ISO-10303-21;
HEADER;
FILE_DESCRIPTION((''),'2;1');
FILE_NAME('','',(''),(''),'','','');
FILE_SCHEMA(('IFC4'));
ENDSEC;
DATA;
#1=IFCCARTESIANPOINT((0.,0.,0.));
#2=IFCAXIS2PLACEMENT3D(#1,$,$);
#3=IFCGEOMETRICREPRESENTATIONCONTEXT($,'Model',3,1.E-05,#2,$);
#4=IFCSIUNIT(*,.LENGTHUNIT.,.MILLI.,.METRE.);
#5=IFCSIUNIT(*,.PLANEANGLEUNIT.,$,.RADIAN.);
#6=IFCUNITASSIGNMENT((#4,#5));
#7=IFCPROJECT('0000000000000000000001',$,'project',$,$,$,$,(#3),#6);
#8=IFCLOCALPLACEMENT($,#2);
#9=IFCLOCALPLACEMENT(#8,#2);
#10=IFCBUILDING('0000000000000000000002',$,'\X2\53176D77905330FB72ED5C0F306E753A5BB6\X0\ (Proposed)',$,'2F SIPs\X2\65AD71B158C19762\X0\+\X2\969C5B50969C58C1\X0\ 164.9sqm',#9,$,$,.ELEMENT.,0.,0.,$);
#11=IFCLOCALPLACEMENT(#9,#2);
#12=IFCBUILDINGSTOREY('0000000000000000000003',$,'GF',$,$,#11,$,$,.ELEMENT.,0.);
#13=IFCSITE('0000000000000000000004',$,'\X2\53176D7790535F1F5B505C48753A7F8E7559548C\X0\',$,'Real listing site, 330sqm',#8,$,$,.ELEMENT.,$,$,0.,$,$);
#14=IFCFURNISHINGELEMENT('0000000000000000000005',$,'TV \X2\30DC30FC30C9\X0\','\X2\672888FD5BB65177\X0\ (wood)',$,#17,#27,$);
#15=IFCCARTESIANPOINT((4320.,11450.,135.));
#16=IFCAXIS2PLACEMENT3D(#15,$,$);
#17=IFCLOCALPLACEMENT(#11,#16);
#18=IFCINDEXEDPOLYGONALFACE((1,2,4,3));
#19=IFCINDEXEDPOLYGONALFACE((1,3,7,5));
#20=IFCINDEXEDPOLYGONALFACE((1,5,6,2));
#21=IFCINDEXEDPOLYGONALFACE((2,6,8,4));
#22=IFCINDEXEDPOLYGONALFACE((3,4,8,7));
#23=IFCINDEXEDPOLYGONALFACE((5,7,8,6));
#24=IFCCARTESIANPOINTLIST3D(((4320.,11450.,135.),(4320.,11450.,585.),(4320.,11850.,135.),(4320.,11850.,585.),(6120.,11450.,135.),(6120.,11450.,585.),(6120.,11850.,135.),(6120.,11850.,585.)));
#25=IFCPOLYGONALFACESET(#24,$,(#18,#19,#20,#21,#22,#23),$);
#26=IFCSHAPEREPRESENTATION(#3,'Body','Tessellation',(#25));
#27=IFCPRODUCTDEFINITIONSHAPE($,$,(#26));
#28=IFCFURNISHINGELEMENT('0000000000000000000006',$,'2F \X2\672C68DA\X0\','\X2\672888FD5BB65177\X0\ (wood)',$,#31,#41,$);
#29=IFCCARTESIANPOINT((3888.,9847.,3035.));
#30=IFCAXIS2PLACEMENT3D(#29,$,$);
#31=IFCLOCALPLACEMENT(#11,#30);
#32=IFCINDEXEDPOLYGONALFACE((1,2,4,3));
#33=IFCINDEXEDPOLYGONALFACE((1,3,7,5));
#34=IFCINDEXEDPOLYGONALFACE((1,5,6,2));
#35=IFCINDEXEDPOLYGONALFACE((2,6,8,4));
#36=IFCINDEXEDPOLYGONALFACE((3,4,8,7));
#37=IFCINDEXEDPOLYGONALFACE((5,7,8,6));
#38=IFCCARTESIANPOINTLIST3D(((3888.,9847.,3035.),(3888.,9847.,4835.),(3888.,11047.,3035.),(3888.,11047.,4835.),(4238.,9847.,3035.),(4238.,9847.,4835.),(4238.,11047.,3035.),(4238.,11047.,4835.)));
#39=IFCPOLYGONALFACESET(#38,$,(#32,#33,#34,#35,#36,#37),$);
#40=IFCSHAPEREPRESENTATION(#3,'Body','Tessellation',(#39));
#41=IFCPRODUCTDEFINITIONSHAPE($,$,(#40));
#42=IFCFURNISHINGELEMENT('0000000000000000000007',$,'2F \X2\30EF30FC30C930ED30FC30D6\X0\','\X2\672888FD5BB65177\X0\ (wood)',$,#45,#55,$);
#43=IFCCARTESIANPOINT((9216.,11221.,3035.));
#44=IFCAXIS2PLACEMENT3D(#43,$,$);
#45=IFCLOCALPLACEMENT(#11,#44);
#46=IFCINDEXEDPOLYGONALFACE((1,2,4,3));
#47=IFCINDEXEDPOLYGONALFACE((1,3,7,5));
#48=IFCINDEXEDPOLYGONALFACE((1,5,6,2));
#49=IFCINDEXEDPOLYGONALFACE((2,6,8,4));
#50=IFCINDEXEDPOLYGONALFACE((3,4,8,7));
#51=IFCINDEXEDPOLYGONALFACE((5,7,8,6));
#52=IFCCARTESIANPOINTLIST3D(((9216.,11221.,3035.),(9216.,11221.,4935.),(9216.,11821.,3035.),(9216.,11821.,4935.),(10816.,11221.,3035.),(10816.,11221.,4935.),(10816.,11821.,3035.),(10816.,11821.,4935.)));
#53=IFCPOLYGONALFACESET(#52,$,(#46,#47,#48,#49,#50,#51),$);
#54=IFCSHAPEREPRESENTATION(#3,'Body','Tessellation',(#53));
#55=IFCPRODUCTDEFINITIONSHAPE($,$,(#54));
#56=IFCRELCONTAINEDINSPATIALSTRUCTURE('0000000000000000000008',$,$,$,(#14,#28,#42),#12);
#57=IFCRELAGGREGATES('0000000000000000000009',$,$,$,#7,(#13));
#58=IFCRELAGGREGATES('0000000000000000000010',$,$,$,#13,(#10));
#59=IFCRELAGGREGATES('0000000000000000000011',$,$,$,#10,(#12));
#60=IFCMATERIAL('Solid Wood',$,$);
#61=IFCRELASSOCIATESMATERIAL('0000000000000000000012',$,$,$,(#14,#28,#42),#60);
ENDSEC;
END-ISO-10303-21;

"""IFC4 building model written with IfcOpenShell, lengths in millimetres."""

from ifc_helpers import new_model, si_unit, frame, frame_2d, origin, place, context, project, spatial, rectangle, extrude, material, element, save


model = new_model("IFC4")

# Units and contexts
model_context = context("Model", 3, precision=1e-05, world=origin())
ifc_project = project(units=[si_unit("LENGTHUNIT", "METRE", prefix="MILLI"), si_unit("PLANEANGLEUNIT", "RADIAN")], contexts=[model_context])

# Site, building, storey
site_placement = place(None, origin())
site = spatial("IfcSite", under=ifc_project, at=site_placement, Name="北海道弟子屈町美留和", ObjectType="Real listing site, 330sqm", CompositionType="ELEMENT", RefElevation=0.0)
building_placement = place(site_placement, origin())
building = spatial("IfcBuilding", under=site, at=building_placement, Name="北海道・狭小の町家 (Proposed)", ObjectType="2F SIPs断熱壁面+障子障壁 164.9sqm", CompositionType="ELEMENT", ElevationOfRefHeight=0.0, ElevationOfTerrain=0.0)
storey_placement = place(building_placement, origin())
storey = spatial("IfcBuildingStorey", under=building, at=storey_placement, Name="GF", CompositionType="ELEMENT", Elevation=0.0)

# Shared definitions
ifc_material_1 = material(Name="Solid Wood")

# Furnishing elements
furnishing_1_placement = place(storey_placement, frame((4320.0, 11450.0, 135.0)))
element("IfcFurnishingElement", 1, at=furnishing_1_placement, inside=storey, material=ifc_material_1, Name="TV ボード", Description="木製家具 (wood)", context=model_context, shape_type="SweptSolid", body=[
    extrude(rectangle(XDim=1800.0, YDim=400.0, at=frame_2d((900.0, 200.0))), frame((4320.0, 11450.0, 135.0)), (0.0, 0.0, 1.0), 450.0),
])
furnishing_2_placement = place(storey_placement, frame((3888.0, 9847.0, 3035.0)))
element("IfcFurnishingElement", 2, at=furnishing_2_placement, inside=storey, material=ifc_material_1, Name="2F 本棚", Description="木製家具 (wood)", context=model_context, shape_type="SweptSolid", body=[
    extrude(rectangle(XDim=350.0, YDim=1200.0, at=frame_2d((175.0, 600.0))), frame((3888.0, 9847.0, 3035.0)), (0.0, 0.0, 1.0), 1800.0),
])
furnishing_3_placement = place(storey_placement, frame((9216.0, 11221.0, 3035.0)))
element("IfcFurnishingElement", 3, at=furnishing_3_placement, inside=storey, material=ifc_material_1, Name="2F ワードローブ", Description="木製家具 (wood)", context=model_context, shape_type="SweptSolid", body=[
    extrude(rectangle(XDim=1600.0, YDim=600.0, at=frame_2d((800.0, 300.0))), frame((9216.0, 11221.0, 3035.0)), (0.0, 0.0, 1.0), 1900.0),
])

save(model, "model.ifc")
